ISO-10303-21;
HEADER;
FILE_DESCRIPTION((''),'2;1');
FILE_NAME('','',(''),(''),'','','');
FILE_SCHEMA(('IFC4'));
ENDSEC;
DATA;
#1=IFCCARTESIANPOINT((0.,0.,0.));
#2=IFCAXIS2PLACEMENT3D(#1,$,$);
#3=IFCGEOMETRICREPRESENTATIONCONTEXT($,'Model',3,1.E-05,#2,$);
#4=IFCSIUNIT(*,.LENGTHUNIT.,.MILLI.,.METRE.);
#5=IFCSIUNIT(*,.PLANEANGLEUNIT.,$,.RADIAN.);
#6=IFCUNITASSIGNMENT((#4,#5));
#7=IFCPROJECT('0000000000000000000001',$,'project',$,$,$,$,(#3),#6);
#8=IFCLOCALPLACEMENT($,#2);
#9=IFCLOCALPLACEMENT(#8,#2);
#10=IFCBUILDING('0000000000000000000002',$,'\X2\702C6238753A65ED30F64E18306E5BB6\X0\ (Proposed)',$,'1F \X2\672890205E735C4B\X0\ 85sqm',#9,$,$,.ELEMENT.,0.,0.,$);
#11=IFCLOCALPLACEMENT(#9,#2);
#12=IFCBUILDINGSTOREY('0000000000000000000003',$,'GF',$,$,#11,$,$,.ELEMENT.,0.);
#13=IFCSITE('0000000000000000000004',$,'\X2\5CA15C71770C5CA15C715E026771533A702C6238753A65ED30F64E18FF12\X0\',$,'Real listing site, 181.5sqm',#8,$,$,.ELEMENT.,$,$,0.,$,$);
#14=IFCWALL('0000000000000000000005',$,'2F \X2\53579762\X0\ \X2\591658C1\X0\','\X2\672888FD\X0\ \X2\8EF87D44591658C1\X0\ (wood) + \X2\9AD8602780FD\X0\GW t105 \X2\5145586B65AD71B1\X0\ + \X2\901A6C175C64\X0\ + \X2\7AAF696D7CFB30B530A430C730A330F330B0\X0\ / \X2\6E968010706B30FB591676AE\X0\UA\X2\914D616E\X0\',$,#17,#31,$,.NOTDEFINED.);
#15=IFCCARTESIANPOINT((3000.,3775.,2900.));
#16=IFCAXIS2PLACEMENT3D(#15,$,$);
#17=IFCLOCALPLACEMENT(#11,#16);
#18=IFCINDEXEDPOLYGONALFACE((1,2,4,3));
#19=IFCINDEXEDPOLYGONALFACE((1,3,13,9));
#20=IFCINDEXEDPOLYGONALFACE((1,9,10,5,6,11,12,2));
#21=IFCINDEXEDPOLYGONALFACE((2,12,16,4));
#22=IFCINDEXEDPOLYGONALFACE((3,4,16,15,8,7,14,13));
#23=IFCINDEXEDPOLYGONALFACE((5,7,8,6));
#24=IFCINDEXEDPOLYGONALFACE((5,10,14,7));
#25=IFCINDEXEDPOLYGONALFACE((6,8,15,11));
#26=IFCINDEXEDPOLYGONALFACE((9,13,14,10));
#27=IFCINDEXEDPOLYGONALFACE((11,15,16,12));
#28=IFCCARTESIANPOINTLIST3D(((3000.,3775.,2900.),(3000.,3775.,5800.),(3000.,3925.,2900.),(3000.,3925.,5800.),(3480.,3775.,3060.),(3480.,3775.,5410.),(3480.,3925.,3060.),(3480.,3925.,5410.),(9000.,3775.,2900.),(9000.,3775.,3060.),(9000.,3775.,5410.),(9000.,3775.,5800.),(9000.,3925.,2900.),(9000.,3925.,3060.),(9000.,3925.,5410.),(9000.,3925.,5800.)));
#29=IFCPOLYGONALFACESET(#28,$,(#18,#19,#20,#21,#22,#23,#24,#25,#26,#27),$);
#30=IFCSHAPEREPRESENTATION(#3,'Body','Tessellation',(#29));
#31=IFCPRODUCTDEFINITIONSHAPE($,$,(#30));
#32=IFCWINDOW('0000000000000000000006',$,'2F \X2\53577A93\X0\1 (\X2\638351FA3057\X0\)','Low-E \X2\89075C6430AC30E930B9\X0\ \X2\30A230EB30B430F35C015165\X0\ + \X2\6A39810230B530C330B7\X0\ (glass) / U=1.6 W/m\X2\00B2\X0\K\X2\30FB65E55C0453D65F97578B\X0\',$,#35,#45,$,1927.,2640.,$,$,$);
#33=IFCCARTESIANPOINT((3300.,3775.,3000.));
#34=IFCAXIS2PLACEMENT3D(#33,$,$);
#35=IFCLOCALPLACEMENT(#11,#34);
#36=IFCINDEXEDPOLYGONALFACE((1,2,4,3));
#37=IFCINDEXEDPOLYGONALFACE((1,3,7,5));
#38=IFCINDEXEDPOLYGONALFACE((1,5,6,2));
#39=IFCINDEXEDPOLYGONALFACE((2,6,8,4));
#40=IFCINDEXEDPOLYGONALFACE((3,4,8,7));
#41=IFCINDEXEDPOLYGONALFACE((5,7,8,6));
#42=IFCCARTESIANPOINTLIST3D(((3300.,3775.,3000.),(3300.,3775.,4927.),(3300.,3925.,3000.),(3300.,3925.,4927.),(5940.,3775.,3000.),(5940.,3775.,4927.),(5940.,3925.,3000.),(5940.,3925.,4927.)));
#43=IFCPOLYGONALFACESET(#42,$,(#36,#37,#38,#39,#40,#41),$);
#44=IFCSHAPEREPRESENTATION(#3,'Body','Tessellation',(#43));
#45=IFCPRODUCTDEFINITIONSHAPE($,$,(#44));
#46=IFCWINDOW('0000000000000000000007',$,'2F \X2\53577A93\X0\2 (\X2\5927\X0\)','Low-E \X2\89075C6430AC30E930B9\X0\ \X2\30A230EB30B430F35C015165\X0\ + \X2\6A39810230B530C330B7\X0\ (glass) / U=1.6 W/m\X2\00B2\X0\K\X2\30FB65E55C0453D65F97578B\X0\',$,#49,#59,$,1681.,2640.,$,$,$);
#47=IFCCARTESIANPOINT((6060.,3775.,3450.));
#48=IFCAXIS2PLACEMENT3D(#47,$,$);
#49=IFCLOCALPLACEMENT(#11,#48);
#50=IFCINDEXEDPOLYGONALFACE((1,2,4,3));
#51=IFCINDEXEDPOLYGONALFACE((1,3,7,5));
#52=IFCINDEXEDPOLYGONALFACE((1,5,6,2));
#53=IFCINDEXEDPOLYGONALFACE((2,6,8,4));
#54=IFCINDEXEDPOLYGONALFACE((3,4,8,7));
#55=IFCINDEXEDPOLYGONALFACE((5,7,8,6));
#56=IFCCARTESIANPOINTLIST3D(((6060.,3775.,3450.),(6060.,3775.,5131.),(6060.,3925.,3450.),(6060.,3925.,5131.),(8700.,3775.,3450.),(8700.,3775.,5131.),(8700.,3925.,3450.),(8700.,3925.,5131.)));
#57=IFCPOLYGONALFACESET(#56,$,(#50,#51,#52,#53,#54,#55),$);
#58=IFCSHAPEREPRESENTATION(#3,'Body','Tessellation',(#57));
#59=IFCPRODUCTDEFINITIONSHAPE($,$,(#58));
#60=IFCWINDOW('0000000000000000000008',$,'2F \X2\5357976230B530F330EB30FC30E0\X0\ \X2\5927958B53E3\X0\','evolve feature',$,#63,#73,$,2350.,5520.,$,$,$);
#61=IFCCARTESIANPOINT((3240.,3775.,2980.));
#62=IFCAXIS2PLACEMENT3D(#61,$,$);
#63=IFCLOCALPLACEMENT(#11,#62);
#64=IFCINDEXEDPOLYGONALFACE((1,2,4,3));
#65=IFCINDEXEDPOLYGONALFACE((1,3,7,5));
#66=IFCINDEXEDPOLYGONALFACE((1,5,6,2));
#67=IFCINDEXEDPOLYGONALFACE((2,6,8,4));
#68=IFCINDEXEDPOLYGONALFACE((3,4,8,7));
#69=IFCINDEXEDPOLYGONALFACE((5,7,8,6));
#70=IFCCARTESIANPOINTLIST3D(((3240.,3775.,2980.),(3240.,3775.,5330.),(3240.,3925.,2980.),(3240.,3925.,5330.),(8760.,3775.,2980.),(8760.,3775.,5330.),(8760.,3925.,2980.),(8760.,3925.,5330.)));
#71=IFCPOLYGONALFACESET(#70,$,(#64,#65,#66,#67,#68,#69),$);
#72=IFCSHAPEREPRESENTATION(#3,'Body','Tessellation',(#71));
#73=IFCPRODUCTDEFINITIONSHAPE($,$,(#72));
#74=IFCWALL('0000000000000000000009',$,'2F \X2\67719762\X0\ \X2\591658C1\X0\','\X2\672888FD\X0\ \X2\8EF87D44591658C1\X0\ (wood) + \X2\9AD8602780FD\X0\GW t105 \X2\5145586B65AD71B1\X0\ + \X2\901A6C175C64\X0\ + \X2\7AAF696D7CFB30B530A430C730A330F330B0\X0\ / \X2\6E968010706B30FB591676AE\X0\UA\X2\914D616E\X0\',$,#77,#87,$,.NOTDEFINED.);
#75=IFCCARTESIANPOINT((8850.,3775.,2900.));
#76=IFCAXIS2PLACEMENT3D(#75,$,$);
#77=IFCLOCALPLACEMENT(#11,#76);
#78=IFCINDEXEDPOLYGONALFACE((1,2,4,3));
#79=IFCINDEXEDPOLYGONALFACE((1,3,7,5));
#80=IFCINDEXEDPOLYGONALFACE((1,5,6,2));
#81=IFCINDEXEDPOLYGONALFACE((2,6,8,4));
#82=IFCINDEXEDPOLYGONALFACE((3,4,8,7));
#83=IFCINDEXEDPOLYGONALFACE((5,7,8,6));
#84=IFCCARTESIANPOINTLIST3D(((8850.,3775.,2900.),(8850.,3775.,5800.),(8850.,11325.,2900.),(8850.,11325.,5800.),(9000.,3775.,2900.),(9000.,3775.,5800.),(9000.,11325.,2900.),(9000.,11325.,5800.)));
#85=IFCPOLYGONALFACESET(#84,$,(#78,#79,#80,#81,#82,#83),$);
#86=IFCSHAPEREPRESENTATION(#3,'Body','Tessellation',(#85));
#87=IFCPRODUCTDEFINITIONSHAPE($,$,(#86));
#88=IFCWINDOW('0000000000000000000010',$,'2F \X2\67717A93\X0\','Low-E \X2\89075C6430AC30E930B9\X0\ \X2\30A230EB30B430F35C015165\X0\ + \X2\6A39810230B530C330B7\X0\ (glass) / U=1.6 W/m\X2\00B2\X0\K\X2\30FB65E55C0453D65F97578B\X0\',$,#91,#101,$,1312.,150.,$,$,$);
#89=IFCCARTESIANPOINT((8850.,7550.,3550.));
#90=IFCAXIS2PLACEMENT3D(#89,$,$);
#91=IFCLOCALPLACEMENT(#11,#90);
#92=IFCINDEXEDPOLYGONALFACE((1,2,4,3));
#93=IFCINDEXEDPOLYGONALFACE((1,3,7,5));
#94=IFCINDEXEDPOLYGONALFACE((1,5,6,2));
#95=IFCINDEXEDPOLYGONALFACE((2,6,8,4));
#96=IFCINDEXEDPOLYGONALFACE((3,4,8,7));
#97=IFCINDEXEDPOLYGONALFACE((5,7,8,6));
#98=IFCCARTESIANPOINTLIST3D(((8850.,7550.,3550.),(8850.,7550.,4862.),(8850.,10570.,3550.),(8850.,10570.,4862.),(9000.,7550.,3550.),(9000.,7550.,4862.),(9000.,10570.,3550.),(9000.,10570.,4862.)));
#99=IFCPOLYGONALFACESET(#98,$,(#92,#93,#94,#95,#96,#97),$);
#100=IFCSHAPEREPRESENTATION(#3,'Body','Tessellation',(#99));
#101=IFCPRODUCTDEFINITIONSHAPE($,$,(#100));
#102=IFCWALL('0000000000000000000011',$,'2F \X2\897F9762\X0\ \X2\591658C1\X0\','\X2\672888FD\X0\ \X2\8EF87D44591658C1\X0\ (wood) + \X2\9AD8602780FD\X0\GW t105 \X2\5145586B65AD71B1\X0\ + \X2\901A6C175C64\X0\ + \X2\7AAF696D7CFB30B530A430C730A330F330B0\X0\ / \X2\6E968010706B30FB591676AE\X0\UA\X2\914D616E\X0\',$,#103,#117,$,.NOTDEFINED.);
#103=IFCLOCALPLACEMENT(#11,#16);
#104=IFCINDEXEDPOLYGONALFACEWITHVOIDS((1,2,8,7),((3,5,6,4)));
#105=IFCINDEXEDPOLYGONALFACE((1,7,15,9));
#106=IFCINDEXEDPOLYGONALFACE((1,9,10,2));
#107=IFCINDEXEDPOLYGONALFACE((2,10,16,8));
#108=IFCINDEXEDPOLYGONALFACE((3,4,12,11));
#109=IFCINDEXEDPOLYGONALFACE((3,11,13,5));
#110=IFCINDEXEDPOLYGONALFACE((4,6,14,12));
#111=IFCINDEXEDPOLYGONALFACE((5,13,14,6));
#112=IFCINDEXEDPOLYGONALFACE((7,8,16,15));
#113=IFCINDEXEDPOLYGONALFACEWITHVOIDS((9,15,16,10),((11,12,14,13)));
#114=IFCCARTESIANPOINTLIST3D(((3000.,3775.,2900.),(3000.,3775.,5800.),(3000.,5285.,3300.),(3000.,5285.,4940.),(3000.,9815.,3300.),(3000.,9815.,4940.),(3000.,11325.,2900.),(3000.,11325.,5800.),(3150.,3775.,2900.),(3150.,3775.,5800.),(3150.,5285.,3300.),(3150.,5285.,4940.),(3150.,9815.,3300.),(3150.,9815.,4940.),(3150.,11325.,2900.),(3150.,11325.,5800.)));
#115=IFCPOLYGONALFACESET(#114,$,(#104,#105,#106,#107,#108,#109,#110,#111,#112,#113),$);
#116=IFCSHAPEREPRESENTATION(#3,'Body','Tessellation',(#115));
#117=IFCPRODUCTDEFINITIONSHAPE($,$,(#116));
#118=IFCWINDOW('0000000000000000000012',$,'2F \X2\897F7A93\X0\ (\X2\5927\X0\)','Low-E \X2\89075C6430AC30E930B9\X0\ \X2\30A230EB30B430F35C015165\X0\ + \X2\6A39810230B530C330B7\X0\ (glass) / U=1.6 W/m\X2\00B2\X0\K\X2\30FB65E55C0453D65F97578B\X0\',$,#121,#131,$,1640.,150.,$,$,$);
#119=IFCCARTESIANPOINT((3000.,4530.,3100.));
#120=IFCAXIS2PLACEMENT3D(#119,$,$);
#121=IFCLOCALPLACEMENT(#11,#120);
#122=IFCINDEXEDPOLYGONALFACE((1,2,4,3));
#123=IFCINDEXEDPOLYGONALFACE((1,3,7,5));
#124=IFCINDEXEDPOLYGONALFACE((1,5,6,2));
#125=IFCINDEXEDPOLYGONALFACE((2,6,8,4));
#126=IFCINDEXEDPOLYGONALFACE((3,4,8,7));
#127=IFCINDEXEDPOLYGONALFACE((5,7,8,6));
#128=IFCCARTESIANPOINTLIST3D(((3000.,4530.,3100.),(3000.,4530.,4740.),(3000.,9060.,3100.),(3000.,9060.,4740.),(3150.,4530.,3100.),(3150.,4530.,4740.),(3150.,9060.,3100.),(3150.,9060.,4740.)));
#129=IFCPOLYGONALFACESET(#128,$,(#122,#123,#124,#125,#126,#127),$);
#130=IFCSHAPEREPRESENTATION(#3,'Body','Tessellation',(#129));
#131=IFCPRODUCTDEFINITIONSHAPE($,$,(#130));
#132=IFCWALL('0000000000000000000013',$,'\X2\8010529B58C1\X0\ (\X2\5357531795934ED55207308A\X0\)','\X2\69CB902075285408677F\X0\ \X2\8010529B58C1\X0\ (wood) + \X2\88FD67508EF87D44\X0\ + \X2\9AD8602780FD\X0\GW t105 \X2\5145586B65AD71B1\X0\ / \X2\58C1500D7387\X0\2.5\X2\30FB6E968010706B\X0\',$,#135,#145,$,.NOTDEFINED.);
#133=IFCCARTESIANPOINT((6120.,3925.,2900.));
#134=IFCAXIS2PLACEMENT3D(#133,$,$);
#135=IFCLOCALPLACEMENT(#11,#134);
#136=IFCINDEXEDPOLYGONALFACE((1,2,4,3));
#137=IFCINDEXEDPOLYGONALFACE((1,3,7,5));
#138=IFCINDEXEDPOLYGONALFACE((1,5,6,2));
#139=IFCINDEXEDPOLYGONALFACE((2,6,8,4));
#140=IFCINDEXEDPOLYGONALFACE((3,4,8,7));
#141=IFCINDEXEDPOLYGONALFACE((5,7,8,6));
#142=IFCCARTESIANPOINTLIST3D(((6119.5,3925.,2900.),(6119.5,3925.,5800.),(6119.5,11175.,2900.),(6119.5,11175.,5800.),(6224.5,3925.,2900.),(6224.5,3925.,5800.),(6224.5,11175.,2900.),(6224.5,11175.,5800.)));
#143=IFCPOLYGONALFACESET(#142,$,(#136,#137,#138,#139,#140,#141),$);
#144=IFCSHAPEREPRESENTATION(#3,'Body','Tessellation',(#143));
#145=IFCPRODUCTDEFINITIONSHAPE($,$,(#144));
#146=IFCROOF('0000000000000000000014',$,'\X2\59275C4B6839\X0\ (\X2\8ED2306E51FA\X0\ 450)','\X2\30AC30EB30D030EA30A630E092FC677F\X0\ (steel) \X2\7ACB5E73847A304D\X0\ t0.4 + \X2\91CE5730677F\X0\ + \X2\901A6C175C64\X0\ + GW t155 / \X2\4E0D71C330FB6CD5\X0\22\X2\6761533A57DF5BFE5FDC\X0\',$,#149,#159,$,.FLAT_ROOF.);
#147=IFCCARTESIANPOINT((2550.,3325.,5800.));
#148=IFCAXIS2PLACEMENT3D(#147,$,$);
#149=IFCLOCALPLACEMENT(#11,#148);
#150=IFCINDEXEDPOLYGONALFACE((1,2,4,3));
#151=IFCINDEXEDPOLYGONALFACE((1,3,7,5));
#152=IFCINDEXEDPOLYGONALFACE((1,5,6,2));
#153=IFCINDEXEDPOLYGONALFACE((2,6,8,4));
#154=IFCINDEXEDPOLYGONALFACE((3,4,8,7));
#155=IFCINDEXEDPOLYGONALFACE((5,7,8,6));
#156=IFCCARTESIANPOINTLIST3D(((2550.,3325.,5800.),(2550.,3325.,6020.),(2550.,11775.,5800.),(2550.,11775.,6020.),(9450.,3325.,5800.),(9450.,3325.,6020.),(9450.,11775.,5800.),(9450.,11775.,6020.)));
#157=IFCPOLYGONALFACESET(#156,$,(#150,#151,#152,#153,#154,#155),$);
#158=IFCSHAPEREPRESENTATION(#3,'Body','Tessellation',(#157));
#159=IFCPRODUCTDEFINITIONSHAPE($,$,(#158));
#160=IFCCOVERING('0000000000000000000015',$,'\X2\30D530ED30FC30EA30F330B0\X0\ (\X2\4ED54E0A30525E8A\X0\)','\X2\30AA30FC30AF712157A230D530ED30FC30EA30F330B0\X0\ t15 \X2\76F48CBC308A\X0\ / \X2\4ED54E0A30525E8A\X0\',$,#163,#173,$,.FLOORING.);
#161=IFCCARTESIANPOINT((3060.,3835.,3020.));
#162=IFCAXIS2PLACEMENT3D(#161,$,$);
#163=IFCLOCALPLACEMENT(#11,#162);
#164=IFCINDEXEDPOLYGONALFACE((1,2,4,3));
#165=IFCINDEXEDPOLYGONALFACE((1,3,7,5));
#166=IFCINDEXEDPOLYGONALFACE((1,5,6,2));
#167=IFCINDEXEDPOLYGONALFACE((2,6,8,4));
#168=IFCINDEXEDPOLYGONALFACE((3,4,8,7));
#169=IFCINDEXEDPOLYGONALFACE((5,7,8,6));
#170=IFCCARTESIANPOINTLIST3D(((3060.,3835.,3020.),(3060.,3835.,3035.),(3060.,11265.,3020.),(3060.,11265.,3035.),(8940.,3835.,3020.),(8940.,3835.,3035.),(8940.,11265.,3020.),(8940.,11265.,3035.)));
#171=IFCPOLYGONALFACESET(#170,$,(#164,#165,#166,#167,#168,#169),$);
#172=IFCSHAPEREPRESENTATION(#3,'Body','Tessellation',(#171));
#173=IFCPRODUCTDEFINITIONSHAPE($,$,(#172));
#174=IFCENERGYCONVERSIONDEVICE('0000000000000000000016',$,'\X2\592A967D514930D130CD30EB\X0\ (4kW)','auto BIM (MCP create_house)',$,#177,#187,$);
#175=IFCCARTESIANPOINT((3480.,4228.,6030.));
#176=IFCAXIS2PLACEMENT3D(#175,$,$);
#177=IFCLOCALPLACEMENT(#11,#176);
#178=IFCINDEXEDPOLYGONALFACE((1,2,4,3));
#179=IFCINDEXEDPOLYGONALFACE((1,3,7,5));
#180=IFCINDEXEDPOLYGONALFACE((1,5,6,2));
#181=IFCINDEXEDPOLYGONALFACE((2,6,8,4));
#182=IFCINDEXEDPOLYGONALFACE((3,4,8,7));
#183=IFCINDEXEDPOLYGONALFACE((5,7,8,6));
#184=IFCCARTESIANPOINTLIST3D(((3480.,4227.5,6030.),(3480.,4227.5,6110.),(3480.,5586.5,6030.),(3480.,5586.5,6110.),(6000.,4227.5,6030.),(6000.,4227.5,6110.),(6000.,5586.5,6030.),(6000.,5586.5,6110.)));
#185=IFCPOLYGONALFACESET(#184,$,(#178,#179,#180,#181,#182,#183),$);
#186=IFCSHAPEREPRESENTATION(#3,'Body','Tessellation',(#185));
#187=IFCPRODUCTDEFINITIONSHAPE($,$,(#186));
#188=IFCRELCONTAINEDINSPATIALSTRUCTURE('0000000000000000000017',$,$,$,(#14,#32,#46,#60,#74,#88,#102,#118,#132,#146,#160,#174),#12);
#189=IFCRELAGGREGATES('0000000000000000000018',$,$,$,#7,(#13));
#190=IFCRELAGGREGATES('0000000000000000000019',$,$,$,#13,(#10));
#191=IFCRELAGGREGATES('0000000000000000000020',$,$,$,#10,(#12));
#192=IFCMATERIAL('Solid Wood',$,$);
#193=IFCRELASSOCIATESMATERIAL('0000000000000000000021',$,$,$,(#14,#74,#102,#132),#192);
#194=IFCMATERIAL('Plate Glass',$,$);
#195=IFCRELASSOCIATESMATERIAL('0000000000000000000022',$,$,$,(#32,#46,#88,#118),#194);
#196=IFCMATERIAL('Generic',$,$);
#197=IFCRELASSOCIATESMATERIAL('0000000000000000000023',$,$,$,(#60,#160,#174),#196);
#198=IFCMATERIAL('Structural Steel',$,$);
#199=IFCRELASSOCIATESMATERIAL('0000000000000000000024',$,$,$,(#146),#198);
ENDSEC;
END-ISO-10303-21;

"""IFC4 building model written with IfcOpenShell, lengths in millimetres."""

from ifc_helpers import new_model, si_unit, frame, frame_2d, origin, place, context, project, spatial, rectangle, extrude, material, element, fill, save


model = new_model("IFC4")

# Units and contexts
model_context = context("Model", 3, precision=1e-05, world=origin())
ifc_project = project(units=[si_unit("LENGTHUNIT", "METRE", prefix="MILLI"), si_unit("PLANEANGLEUNIT", "RADIAN")], contexts=[model_context])

# Site, building, storey
site_placement = place(None, origin())
site = spatial("IfcSite", under=ifc_project, at=site_placement, Name="岡山県岡山市東区瀬戸町旭ヶ丘２", ObjectType="Real listing site, 181.5sqm", CompositionType="ELEMENT", RefElevation=0.0)
building_placement = place(site_placement, origin())
building = spatial("IfcBuilding", under=site, at=building_placement, Name="瀬戸町旭ヶ丘の家 (Proposed)", ObjectType="1F 木造平屋 85sqm", CompositionType="ELEMENT", ElevationOfRefHeight=0.0, ElevationOfTerrain=0.0)
storey_placement = place(building_placement, origin())
storey = spatial("IfcBuildingStorey", under=building, at=storey_placement, Name="GF", CompositionType="ELEMENT", Elevation=0.0)

# Shared definitions
ifc_material_1 = material(Name="Solid Wood")

# Wall, openings, windows
wall_1_placement = place(storey_placement, frame((3000.0, 3775.0, 2900.0)))
wall_1 = element("IfcWall", 1, at=wall_1_placement, inside=storey, material=ifc_material_1, Name="2F 南面 外壁", Description="木製 軸組外壁 (wood) + 高性能GW t105 充填断熱 + 通気層 + 窯業系サイディング / 準耐火・外皮UA配慮", PredefinedType="NOTDEFINED", context=model_context, shape_type="SweptSolid", body=[
    extrude(rectangle(XDim=6000.0, YDim=150.0, at=frame_2d((3000.0, 75.0))), frame((3000.0, 3775.0, 2900.0)), (0.0, 0.0, 1.0), 2900.0),
])
opening_1_placement = place(storey_placement, frame((3300.0, 3775.0, 3000.0)))
opening_1 = element("IfcOpeningElement", 2, at=opening_1_placement, cuts=wall_1, PredefinedType="NOTDEFINED", context=model_context, shape_type="SweptSolid", body=[
    extrude(rectangle(XDim=2640.0, YDim=150.0, at=frame_2d((1320.0, 75.0))), frame((3300.0, 3775.0, 3000.0)), (0.0, 0.0, 1.0), 1927.0),
])
opening_2_placement = place(storey_placement, frame((6060.0, 3775.0, 3450.0)))
opening_2 = element("IfcOpeningElement", 3, at=opening_2_placement, cuts=wall_1, PredefinedType="NOTDEFINED", context=model_context, shape_type="SweptSolid", body=[
    extrude(rectangle(XDim=2640.0, YDim=150.0, at=frame_2d((1320.0, 75.0))), frame((6060.0, 3775.0, 3450.0)), (0.0, 0.0, 1.0), 1681.0),
])
opening_3_placement = place(storey_placement, frame((3240.0, 3775.0, 2980.0)))
opening_3 = element("IfcOpeningElement", 4, at=opening_3_placement, cuts=wall_1, PredefinedType="NOTDEFINED", context=model_context, shape_type="SweptSolid", body=[
    extrude(rectangle(XDim=5520.0, YDim=150.0, at=frame_2d((2760.0, 75.0))), frame((3240.0, 3775.0, 2980.0)), (0.0, 0.0, 1.0), 2350.0),
])
ifc_material_2 = material(Name="Plate Glass")
window_1_placement = place(storey_placement, frame((3300.0, 3775.0, 3000.0)))
window_1 = element("IfcWindow", 5, at=window_1_placement, inside=storey, material=ifc_material_2, Name="2F 南窓1 (掃出し)", Description="Low-E 複層ガラス アルゴン封入 + 樹脂サッシ (glass) / U=1.6 W/m²K・日射取得型", OverallHeight=1927.0, OverallWidth=2640.0, context=model_context, shape_type="SweptSolid", body=[
    extrude(rectangle(XDim=2640.0, YDim=150.0, at=frame_2d((1320.0, 75.0))), frame((3300.0, 3775.0, 3000.0)), (0.0, 0.0, 1.0), 1927.0),
])
fill(opening_1, window_1)
window_2_placement = place(storey_placement, frame((6060.0, 3775.0, 3450.0)))
window_2 = element("IfcWindow", 6, at=window_2_placement, inside=storey, material=ifc_material_2, Name="2F 南窓2 (大)", Description="Low-E 複層ガラス アルゴン封入 + 樹脂サッシ (glass) / U=1.6 W/m²K・日射取得型", OverallHeight=1681.0, OverallWidth=2640.0, context=model_context, shape_type="SweptSolid", body=[
    extrude(rectangle(XDim=2640.0, YDim=150.0, at=frame_2d((1320.0, 75.0))), frame((6060.0, 3775.0, 3450.0)), (0.0, 0.0, 1.0), 1681.0),
])
fill(opening_2, window_2)
ifc_material_3 = material(Name="Generic")
window_3_placement = place(storey_placement, frame((3240.0, 3775.0, 2980.0)))
window_3 = element("IfcWindow", 7, at=window_3_placement, inside=storey, material=ifc_material_3, Name="2F 南面サンルーム 大開口", Description="evolve feature", OverallHeight=2350.0, OverallWidth=5520.0, context=model_context, shape_type="SweptSolid", body=[
    extrude(rectangle(XDim=5520.0, YDim=150.0, at=frame_2d((2760.0, 75.0))), frame((3240.0, 3775.0, 2980.0)), (0.0, 0.0, 1.0), 2350.0),
])
fill(opening_3, window_3)

# Walls, openings, windows
wall_2_placement = place(storey_placement, frame((8850.0, 3775.0, 2900.0)))
wall_2 = element("IfcWall", 8, at=wall_2_placement, inside=storey, material=ifc_material_1, Name="2F 東面 外壁", Description="木製 軸組外壁 (wood) + 高性能GW t105 充填断熱 + 通気層 + 窯業系サイディング / 準耐火・外皮UA配慮", PredefinedType="NOTDEFINED", context=model_context, shape_type="SweptSolid", body=[
    extrude(rectangle(XDim=150.0, YDim=7550.0, at=frame_2d((75.0, 3775.0))), frame((8850.0, 3775.0, 2900.0)), (0.0, 0.0, 1.0), 2900.0),
])
opening_4_placement = place(storey_placement, frame((8850.0, 7550.0, 3550.0)))
opening_4 = element("IfcOpeningElement", 9, at=opening_4_placement, cuts=wall_2, PredefinedType="NOTDEFINED", context=model_context, shape_type="SweptSolid", body=[
    extrude(rectangle(XDim=150.0, YDim=3020.0, at=frame_2d((75.0, 1510.0))), frame((8850.0, 7550.0, 3550.0)), (0.0, 0.0, 1.0), 1312.0),
])
window_4_placement = place(storey_placement, frame((8850.0, 7550.0, 3550.0)))
window_4 = element("IfcWindow", 10, at=window_4_placement, inside=storey, material=ifc_material_2, Name="2F 東窓", Description="Low-E 複層ガラス アルゴン封入 + 樹脂サッシ (glass) / U=1.6 W/m²K・日射取得型", OverallHeight=1312.0, OverallWidth=150.0, context=model_context, shape_type="SweptSolid", body=[
    extrude(rectangle(XDim=150.0, YDim=3020.0, at=frame_2d((75.0, 1510.0))), frame((8850.0, 7550.0, 3550.0)), (0.0, 0.0, 1.0), 1312.0),
])
fill(opening_4, window_4)
wall_3_placement = place(storey_placement, frame((3000.0, 3775.0, 2900.0)))
wall_3 = element("IfcWall", 11, at=wall_3_placement, inside=storey, material=ifc_material_1, Name="2F 西面 外壁", Description="木製 軸組外壁 (wood) + 高性能GW t105 充填断熱 + 通気層 + 窯業系サイディング / 準耐火・外皮UA配慮", PredefinedType="NOTDEFINED", context=model_context, shape_type="SweptSolid", body=[
    extrude(rectangle(XDim=150.0, YDim=7550.0, at=frame_2d((75.0, 3775.0))), frame((3000.0, 3775.0, 2900.0)), (0.0, 0.0, 1.0), 2900.0),
])
opening_5_placement = place(storey_placement, frame((3000.0, 4530.0, 3100.0)))
opening_5 = element("IfcOpeningElement", 12, at=opening_5_placement, cuts=wall_3, PredefinedType="NOTDEFINED", context=model_context, shape_type="SweptSolid", body=[
    extrude(rectangle(XDim=150.0, YDim=4530.0, at=frame_2d((75.0, 2265.0))), frame((3000.0, 4530.0, 3100.0)), (0.0, 0.0, 1.0), 1640.0),
])
window_5_placement = place(storey_placement, frame((3000.0, 4530.0, 3100.0)))
window_5 = element("IfcWindow", 13, at=window_5_placement, inside=storey, material=ifc_material_2, Name="2F 西窓 (大)", Description="Low-E 複層ガラス アルゴン封入 + 樹脂サッシ (glass) / U=1.6 W/m²K・日射取得型", OverallHeight=1640.0, OverallWidth=150.0, context=model_context, shape_type="SweptSolid", body=[
    extrude(rectangle(XDim=150.0, YDim=4530.0, at=frame_2d((75.0, 2265.0))), frame((3000.0, 4530.0, 3100.0)), (0.0, 0.0, 1.0), 1640.0),
])
fill(opening_5, window_5)

# Wall
wall_4_placement = place(storey_placement, frame((6120.0, 3925.0, 2900.0)))
element("IfcWall", 14, at=wall_4_placement, inside=storey, material=ifc_material_1, Name="耐力壁 (南北間仕切り)", Description="構造用合板 耐力壁 (wood) + 製材軸組 + 高性能GW t105 充填断熱 / 壁倍率2.5・準耐火", PredefinedType="NOTDEFINED", context=model_context, shape_type="SweptSolid", body=[
    extrude(rectangle(XDim=105.0, YDim=7250.0, at=frame_2d((52.0, 3625.0))), frame((6120.0, 3925.0, 2900.0)), (0.0, 0.0, 1.0), 2900.0),
])

# Roof
ifc_material_4 = material(Name="Structural Steel")
roof_placement = place(storey_placement, frame((2550.0, 3325.0, 5800.0)))
element("IfcRoof", 15, at=roof_placement, inside=storey, material=ifc_material_4, Name="大屋根 (軒の出 450)", Description="ガルバリウム鋼板 (steel) 立平葺き t0.4 + 野地板 + 通気層 + GW t155 / 不燃・法22条区域対応", PredefinedType="FLAT_ROOF", context=model_context, shape_type="SweptSolid", body=[
    extrude(rectangle(XDim=6900.0, YDim=8450.0, at=frame_2d((3450.0, 4225.0))), frame((2550.0, 3325.0, 5800.0)), (0.0, 0.0, 1.0), 220.0),
])

# Covering
covering_placement = place(storey_placement, frame((3060.0, 3835.0, 3020.0)))
element("IfcCovering", 16, at=covering_placement, inside=storey, material=ifc_material_3, Name="フローリング (仕上げ床)", Description="オーク無垢フローリング t15 直貼り / 仕上げ床", PredefinedType="FLOORING", context=model_context, shape_type="SweptSolid", body=[
    extrude(rectangle(XDim=5880.0, YDim=7430.0, at=frame_2d((2940.0, 3715.0))), frame((3060.0, 3835.0, 3020.0)), (0.0, 0.0, 1.0), 15.0),
])

# Energy conversion device
energy_conversion_device_placement = place(storey_placement, frame((3480.0, 4228.0, 6030.0)))
element("IfcEnergyConversionDevice", 17, at=energy_conversion_device_placement, inside=storey, material=ifc_material_3, Name="太陽光パネル (4kW)", Description="auto BIM (MCP create_house)", context=model_context, shape_type="SweptSolid", body=[
    extrude(rectangle(XDim=2520.0, YDim=1359.0, at=frame_2d((1260.0, 679.0))), frame((3480.0, 4228.0, 6030.0)), (0.0, 0.0, 1.0), 80.0),
])

save(model, "model.ifc")
